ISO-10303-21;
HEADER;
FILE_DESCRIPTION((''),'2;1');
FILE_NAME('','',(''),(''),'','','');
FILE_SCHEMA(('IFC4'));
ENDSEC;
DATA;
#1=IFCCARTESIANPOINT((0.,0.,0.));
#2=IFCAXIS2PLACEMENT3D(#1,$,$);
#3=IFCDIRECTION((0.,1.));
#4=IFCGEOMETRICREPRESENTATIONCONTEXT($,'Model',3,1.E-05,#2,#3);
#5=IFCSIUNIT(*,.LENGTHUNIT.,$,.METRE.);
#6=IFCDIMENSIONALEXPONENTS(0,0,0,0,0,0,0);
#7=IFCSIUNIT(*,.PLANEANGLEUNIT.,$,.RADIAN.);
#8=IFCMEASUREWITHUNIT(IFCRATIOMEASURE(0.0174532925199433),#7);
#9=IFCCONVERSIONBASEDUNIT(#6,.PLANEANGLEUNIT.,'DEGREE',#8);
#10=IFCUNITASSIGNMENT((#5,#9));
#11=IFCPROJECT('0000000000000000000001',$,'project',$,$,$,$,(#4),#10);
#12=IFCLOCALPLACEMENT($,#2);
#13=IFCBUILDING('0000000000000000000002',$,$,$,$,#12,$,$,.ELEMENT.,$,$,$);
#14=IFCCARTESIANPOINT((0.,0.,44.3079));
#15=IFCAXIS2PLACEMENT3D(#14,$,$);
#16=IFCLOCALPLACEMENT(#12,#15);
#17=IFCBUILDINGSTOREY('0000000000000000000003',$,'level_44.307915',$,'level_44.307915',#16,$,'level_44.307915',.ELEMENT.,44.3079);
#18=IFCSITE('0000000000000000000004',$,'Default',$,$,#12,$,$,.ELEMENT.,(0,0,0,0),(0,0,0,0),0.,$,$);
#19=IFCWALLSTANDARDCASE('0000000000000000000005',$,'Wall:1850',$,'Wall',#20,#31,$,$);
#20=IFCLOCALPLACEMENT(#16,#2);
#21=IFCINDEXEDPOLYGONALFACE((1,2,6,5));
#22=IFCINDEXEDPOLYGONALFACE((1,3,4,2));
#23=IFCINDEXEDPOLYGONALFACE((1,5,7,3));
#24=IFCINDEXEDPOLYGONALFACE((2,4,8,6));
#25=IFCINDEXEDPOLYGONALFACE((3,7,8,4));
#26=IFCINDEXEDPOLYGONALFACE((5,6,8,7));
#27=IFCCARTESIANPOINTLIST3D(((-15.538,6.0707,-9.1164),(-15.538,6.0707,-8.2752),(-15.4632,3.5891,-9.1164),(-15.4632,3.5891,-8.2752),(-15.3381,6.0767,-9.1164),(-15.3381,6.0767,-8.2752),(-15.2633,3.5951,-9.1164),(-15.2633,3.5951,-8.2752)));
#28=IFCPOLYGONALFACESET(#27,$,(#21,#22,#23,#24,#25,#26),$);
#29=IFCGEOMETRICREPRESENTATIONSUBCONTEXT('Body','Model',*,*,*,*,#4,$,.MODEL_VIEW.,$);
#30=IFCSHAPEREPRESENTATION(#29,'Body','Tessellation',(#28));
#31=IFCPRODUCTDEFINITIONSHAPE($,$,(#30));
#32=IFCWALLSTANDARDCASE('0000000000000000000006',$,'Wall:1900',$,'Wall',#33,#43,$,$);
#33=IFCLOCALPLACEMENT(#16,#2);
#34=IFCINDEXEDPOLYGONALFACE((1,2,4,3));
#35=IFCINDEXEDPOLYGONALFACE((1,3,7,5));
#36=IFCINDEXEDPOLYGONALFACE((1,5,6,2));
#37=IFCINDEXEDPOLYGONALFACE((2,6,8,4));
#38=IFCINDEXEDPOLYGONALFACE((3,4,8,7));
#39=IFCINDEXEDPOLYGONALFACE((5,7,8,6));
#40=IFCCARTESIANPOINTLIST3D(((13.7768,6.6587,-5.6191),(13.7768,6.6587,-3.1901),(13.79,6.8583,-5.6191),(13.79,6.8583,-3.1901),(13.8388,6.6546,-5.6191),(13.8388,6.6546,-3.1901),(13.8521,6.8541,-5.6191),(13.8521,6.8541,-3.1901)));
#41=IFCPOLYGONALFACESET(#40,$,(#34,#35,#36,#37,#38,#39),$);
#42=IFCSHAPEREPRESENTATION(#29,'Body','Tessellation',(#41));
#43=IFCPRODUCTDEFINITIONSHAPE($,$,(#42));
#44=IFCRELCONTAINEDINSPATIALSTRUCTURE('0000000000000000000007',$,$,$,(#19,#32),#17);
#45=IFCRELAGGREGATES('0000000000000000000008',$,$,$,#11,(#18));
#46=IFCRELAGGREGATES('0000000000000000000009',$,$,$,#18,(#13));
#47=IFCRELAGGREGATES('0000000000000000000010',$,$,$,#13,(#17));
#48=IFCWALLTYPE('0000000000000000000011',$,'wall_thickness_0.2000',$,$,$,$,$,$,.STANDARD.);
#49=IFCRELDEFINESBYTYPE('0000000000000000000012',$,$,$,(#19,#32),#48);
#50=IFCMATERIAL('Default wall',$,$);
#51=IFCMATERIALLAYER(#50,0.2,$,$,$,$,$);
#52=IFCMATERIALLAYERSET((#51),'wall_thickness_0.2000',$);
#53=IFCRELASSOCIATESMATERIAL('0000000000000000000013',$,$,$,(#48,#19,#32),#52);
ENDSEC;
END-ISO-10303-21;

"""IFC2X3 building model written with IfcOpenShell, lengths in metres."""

from ifc_helpers import new_model, entity, si_unit, converted_unit, direction, frame, origin, place, context, subcontext, project, spatial, polyline, outline, extrude, material, layer, layer_set, layer_usage, type_object, element, save


model = new_model("IFC2X3")

# Units and contexts
model_context = context("Model", 3, precision=1e-05, world=origin(), true_north=direction((0.0, 1.0)))
body_context = subcontext(model_context, "Body", "Model", "MODEL_VIEW")
ifc_project = project(units=[si_unit("LENGTHUNIT", "METRE"), converted_unit("PLANEANGLEUNIT", "DEGREE", entity("IfcRatioMeasure", 0.0174532925199433), si_unit("PLANEANGLEUNIT", "RADIAN"), dimensions=[0, 0, 0, 0, 0, 0, 0])], contexts=[model_context])

# Site, building, storey
placement_1 = place(None, origin())
site = spatial("IfcSite", under=ifc_project, at=placement_1, Name="Default", CompositionType="ELEMENT", RefLatitude=(0, 0, 0, 0), RefLongitude=(0, 0, 0, 0), RefElevation=0.0)
building = spatial("IfcBuilding", under=site, at=placement_1, CompositionType="ELEMENT")
storey_placement = place(placement_1, frame((0.0, 0.0, 44.3079)))
storey = spatial("IfcBuildingStorey", under=building, at=storey_placement, Name="level_44.307915", ObjectType="level_44.307915", LongName="level_44.307915", CompositionType="ELEMENT", Elevation=44.3079)

# Walls
ifc_material = material(Name="Default wall")
ifc_layer = layer(ifc_material, 0.2)
ifc_layer_set = layer_set([ifc_layer], Name="wall_thickness_0.2000")
ifc_layer_usage = layer_usage(ifc_layer_set, "AXIS2", "POSITIVE", -0.1)
wall_type = type_object("IfcWallType", Name="wall_thickness_0.2000", PredefinedType="STANDARD", material=ifc_layer_set)
placement_2 = place(placement_1, frame((0.0, 0.0, 35.1915)))
wall_1_placement = place(placement_2, frame((-15.3633, 3.5921, 0.0), z_axis=(0.0, 0.0, 1.0), x_axis=(-0.03014, 0.999546, 0.0)))
element("IfcWallStandardCase", 1, at=wall_1_placement, inside=storey, type_object=wall_type, material=ifc_layer_usage, Name="Wall:1850", ObjectType="Wall", context=body_context, shape_type="SweptSolid", body=[
    extrude(outline(polyline([(2.4827, -0.1), (2.4827, 0.1), (0.0, 0.1), (0.0, -0.1), (2.4827, -0.1)])), origin(), (0.0, 0.0, 1.0), 0.8412),
])
placement_3 = place(placement_1, frame((0.0, 0.0, 38.6888)))
wall_2_placement = place(placement_3, frame((13.8455, 6.7544, 0.0), z_axis=(0.0, 0.0, 1.0), x_axis=(-0.997806, 0.066201, 0.0)))
element("IfcWallStandardCase", 2, at=wall_2_placement, inside=storey, type_object=wall_type, material=ifc_layer_usage, Name="Wall:1900", ObjectType="Wall", context=body_context, shape_type="SweptSolid", body=[
    extrude(outline(polyline([(0.0622, -0.1), (0.0622, 0.1), (0.0, 0.1), (0.0, -0.1), (0.0622, -0.1)])), origin(), (0.0, 0.0, 1.0), 2.4289),
])

save(model, "model.ifc")
